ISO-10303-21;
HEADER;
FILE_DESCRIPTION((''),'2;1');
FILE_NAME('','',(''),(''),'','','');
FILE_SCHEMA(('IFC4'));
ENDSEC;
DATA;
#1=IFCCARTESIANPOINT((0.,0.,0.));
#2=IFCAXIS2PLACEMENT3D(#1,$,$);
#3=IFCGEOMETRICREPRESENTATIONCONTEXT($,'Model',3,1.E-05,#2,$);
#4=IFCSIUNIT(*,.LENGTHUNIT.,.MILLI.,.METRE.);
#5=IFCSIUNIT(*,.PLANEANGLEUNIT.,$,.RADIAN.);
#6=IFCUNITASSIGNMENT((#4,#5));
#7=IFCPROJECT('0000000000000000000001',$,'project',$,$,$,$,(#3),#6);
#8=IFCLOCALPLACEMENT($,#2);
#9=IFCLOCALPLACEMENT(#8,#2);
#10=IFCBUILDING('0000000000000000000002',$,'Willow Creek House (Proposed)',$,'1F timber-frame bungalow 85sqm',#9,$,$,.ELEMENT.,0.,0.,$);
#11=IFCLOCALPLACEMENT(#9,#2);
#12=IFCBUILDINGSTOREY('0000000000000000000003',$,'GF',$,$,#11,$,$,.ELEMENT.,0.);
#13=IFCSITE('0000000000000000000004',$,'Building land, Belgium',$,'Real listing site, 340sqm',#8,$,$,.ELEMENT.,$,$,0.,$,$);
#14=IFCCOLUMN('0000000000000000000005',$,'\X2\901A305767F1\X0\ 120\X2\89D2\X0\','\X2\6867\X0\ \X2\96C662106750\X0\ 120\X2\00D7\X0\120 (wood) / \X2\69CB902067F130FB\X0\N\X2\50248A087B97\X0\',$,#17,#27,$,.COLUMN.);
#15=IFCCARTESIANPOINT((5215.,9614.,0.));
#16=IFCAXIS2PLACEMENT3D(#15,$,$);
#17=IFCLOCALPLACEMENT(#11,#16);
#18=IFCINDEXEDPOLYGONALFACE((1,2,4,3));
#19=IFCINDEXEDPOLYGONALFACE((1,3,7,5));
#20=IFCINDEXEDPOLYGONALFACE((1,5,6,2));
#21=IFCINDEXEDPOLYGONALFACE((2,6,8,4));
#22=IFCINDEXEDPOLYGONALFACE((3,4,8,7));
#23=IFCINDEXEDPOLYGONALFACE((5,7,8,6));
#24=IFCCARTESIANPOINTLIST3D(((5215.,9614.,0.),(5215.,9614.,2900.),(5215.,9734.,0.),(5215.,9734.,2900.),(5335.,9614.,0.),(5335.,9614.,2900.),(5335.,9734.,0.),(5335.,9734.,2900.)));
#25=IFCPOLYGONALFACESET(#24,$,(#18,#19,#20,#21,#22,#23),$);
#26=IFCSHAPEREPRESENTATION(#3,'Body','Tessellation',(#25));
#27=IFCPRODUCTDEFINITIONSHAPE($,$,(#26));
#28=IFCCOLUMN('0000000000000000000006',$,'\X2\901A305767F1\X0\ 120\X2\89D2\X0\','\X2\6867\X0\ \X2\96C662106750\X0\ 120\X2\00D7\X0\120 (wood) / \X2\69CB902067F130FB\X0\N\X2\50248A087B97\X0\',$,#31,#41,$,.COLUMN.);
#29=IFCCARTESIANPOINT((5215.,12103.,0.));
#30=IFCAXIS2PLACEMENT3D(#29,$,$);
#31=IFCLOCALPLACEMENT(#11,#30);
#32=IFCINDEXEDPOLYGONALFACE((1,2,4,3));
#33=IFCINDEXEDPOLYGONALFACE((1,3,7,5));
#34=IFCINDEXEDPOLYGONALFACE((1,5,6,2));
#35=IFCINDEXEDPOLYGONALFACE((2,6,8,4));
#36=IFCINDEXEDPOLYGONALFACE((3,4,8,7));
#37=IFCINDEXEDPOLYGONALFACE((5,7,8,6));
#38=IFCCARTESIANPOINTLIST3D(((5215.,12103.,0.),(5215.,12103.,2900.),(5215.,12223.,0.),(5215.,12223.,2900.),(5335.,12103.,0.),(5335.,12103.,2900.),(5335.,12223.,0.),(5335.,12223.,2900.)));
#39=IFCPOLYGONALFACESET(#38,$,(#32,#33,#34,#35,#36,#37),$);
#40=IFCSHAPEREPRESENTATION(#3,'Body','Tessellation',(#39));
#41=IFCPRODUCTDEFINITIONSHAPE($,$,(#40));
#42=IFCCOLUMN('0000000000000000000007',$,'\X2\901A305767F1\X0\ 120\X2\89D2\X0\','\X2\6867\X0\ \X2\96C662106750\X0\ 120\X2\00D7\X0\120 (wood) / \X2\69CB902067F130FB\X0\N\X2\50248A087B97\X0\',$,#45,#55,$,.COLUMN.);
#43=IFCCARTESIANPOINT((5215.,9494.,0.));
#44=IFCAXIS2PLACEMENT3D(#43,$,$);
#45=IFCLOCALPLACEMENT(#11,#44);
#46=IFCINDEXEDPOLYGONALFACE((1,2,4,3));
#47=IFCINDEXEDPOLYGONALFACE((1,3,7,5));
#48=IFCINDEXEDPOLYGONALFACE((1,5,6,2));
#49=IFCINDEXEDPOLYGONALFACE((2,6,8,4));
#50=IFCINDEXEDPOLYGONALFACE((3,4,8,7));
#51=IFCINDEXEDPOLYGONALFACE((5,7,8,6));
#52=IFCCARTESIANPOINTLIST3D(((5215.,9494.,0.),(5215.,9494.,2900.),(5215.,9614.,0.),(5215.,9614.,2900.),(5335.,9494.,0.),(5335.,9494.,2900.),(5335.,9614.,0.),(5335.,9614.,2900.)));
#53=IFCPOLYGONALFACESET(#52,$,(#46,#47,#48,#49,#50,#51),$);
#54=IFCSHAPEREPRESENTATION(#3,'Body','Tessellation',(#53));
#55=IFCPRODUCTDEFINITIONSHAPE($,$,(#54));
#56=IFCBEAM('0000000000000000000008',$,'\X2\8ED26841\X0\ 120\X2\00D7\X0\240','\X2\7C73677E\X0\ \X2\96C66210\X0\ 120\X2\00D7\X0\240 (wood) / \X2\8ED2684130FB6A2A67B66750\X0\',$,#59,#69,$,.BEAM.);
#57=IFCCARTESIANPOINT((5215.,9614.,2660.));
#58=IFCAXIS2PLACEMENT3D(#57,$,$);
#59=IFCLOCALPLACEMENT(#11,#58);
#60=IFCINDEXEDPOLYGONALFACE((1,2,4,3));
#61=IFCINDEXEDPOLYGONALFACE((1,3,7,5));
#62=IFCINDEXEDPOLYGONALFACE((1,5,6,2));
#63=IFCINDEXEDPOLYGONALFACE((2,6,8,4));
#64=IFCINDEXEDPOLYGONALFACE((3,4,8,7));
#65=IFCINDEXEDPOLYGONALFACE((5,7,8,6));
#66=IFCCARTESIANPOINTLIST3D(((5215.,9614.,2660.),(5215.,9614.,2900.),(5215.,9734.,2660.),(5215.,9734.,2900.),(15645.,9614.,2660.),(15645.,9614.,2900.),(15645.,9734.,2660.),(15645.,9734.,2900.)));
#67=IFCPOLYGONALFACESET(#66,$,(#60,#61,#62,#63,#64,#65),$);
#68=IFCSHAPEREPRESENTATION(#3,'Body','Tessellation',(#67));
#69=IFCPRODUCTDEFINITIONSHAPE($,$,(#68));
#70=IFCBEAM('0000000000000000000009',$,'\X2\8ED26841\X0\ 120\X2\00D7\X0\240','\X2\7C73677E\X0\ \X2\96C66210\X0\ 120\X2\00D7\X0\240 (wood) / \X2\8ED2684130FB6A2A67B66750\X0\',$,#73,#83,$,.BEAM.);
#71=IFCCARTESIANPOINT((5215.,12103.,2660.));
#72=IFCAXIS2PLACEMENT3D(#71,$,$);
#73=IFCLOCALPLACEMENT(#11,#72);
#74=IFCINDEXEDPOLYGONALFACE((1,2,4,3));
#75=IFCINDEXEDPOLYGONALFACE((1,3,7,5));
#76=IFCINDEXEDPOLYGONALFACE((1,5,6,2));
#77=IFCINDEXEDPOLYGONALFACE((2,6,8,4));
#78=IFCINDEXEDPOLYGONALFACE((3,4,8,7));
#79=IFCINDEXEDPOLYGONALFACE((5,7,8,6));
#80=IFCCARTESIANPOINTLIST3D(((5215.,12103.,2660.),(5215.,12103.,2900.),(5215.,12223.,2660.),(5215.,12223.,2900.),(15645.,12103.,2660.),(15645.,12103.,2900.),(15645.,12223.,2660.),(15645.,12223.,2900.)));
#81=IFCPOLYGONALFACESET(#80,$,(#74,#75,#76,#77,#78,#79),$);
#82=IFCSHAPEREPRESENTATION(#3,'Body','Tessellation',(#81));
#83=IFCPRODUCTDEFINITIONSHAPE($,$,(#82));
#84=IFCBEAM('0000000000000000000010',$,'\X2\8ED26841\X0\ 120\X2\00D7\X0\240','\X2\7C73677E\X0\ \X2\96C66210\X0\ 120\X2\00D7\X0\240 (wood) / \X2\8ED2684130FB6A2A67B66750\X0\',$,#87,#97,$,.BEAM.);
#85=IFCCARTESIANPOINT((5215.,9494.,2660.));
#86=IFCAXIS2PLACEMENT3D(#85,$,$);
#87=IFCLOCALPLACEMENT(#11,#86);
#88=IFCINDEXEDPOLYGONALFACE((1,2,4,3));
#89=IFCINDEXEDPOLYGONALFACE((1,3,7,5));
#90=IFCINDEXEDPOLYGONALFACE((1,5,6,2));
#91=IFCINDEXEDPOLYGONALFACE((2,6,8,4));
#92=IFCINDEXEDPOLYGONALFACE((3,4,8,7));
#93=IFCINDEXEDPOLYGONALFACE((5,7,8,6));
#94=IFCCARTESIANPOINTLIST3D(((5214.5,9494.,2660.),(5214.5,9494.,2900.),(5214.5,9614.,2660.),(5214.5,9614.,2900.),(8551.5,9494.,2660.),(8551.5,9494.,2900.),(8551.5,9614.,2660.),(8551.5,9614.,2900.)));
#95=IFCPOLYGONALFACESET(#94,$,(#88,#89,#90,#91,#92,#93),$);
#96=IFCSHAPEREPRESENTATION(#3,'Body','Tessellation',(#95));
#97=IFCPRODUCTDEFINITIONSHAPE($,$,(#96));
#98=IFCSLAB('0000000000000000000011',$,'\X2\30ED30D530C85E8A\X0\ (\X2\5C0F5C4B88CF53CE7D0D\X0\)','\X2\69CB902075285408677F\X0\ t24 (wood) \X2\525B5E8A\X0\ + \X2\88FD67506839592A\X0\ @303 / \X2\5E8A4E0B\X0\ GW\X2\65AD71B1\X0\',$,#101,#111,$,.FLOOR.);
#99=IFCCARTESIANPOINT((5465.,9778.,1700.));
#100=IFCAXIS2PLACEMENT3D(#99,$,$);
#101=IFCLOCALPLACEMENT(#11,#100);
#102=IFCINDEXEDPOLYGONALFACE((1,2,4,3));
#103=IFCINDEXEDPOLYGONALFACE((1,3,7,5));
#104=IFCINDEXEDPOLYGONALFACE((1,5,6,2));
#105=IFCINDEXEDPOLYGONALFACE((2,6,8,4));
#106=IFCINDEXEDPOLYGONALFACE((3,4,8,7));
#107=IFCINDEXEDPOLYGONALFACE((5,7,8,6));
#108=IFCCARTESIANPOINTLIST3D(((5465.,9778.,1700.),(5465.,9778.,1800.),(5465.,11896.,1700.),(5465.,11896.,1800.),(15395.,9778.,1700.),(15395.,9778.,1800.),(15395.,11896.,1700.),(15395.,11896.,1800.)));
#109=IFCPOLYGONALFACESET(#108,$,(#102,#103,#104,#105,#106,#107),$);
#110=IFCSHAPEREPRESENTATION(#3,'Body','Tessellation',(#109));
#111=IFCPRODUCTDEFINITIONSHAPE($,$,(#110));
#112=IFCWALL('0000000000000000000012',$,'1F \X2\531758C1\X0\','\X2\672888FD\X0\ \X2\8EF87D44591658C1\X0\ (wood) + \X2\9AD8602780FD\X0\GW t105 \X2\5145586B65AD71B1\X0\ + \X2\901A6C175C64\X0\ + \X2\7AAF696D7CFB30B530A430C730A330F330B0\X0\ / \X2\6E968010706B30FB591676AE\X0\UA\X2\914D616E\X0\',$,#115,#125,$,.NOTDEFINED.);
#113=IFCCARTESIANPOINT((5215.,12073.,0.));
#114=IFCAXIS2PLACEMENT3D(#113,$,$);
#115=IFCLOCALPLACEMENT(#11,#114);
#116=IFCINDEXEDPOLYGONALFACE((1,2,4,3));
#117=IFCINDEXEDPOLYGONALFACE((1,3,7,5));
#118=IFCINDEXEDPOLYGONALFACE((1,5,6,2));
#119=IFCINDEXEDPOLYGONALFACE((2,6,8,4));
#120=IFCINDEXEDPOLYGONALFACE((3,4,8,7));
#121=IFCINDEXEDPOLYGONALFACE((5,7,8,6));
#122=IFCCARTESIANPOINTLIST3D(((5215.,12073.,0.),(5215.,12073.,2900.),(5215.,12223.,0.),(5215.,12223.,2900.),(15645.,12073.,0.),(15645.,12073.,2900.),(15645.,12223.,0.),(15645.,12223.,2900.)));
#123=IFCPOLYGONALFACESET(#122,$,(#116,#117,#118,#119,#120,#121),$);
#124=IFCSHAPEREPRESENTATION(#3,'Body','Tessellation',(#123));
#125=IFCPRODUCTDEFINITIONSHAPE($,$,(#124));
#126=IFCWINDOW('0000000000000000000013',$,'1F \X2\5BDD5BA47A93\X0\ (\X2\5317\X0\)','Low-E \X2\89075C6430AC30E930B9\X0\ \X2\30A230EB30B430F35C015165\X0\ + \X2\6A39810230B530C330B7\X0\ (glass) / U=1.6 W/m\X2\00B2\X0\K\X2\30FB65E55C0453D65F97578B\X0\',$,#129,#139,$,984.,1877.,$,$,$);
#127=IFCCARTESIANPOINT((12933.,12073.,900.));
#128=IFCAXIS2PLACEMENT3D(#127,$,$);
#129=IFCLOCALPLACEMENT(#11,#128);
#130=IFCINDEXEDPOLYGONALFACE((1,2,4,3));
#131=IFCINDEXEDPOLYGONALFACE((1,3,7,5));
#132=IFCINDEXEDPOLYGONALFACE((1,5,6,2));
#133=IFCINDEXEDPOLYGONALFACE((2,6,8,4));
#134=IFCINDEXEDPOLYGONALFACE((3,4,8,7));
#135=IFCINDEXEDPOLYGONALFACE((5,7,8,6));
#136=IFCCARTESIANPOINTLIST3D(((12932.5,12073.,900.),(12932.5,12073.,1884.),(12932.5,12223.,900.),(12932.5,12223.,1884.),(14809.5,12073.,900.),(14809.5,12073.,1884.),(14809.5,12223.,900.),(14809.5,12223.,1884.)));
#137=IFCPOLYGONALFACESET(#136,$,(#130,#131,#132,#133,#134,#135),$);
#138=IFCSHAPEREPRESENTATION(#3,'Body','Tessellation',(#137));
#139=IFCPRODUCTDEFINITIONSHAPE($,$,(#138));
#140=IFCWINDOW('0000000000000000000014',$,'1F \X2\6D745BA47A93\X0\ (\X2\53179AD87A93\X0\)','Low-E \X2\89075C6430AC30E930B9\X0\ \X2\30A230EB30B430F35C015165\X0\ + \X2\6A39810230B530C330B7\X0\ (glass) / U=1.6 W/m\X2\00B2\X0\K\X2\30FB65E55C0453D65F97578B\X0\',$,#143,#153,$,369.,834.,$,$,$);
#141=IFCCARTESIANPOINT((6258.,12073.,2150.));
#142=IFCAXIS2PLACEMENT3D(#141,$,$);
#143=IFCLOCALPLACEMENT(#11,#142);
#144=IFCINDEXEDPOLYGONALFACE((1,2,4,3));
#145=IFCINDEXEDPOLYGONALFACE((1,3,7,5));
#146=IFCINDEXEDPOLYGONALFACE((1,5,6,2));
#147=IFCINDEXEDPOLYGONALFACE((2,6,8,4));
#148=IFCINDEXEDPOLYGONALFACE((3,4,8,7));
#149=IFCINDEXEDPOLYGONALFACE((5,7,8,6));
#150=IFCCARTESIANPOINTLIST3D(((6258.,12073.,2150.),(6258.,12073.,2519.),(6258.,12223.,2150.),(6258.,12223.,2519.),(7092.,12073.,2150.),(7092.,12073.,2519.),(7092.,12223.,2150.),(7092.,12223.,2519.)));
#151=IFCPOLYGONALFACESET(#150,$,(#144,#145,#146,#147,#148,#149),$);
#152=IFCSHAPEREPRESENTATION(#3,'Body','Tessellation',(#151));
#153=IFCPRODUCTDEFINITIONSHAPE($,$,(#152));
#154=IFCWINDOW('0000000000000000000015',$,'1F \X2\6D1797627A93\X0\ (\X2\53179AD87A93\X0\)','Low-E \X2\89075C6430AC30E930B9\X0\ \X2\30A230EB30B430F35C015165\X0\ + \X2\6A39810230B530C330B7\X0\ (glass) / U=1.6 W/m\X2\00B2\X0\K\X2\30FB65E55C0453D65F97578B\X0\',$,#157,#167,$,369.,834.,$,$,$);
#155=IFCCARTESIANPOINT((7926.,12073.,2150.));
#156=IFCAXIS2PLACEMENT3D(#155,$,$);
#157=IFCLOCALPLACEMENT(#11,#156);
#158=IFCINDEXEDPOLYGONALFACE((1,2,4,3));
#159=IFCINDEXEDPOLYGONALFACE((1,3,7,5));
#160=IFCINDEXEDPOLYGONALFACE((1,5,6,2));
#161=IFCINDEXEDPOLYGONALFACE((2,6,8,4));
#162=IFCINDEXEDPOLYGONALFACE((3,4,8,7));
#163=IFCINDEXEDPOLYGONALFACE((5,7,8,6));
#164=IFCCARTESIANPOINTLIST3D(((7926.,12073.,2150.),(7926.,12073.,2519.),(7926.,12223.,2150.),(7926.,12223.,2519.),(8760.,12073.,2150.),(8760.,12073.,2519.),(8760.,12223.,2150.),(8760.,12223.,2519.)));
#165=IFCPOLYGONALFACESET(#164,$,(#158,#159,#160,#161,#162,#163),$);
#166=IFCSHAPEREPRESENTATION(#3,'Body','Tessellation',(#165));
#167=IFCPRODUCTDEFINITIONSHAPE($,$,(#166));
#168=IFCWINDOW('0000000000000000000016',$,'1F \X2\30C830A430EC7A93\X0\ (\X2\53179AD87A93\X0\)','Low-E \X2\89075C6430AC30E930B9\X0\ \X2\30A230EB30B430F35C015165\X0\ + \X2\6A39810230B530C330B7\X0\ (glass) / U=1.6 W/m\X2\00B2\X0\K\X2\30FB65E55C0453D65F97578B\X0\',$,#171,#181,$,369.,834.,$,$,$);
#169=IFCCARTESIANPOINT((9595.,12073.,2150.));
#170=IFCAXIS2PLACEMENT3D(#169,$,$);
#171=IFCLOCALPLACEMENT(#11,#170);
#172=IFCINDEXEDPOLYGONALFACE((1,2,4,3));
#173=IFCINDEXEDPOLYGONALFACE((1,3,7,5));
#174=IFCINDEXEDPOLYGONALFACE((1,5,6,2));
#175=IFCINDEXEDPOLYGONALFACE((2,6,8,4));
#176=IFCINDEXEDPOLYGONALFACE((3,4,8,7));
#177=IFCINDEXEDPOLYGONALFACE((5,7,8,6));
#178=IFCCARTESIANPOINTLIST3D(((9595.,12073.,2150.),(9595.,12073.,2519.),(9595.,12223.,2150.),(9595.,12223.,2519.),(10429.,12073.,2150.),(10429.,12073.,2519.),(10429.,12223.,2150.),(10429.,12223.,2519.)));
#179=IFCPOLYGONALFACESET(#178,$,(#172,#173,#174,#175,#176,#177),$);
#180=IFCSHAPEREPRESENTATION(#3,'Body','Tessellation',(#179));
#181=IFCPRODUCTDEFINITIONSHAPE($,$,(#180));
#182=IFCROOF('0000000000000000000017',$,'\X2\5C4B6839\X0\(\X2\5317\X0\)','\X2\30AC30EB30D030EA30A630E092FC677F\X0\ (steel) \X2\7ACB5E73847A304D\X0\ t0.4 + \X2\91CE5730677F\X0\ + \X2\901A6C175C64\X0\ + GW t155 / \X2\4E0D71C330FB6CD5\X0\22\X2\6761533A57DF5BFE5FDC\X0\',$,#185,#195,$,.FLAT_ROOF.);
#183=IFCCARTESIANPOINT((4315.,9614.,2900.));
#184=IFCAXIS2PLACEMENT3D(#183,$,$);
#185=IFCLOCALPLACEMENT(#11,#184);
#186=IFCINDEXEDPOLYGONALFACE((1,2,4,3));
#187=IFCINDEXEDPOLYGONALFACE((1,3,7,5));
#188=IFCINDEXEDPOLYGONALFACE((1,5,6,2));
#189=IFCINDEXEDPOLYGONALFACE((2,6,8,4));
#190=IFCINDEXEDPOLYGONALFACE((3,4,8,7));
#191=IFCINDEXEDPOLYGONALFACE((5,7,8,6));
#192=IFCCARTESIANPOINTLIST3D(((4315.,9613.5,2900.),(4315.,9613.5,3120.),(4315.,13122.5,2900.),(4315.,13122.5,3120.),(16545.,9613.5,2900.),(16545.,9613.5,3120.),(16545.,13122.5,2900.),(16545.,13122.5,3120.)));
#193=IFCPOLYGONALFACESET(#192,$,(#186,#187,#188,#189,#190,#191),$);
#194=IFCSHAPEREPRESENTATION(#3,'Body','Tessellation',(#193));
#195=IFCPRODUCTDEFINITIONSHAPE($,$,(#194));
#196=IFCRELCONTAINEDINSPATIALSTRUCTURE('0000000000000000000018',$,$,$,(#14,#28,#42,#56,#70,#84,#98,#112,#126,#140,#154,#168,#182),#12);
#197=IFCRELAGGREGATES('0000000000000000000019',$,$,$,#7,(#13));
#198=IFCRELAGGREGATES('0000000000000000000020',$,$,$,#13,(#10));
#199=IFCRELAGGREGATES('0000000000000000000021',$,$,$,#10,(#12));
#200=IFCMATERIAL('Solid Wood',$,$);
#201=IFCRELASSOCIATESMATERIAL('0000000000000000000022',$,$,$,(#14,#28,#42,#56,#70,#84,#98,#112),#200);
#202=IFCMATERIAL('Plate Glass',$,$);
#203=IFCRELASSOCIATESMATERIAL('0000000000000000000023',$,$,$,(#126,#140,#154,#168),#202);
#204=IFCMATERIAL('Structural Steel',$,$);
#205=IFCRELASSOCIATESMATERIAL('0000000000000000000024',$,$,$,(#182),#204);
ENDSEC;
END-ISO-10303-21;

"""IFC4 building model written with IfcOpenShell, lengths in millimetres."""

from ifc_helpers import new_model, si_unit, frame, frame_2d, origin, place, context, project, spatial, rectangle, extrude, material, element, fill, save


model = new_model("IFC4")

# Units and contexts
model_context = context("Model", 3, precision=1e-05, world=origin())
ifc_project = project(units=[si_unit("LENGTHUNIT", "METRE", prefix="MILLI"), si_unit("PLANEANGLEUNIT", "RADIAN")], contexts=[model_context])

# Site, building, storey
site_placement = place(None, origin())
site = spatial("IfcSite", under=ifc_project, at=site_placement, Name="Building land, Belgium", ObjectType="Real listing site, 340sqm", CompositionType="ELEMENT", RefElevation=0.0)
building_placement = place(site_placement, origin())
building = spatial("IfcBuilding", under=site, at=building_placement, Name="Willow Creek House (Proposed)", ObjectType="1F timber-frame bungalow 85sqm", CompositionType="ELEMENT", ElevationOfRefHeight=0.0, ElevationOfTerrain=0.0)
storey_placement = place(building_placement, origin())
storey = spatial("IfcBuildingStorey", under=building, at=storey_placement, Name="GF", CompositionType="ELEMENT", Elevation=0.0)

# Columns
ifc_material_1 = material(Name="Solid Wood")
column_1_placement = place(storey_placement, frame((5215.0, 9614.0, 0.0)))
element("IfcColumn", 1, at=column_1_placement, inside=storey, material=ifc_material_1, Name="通し柱 120角", Description="桧 集成材 120×120 (wood) / 構造柱・N値計算", PredefinedType="COLUMN", context=model_context, shape_type="SweptSolid", body=[
    extrude(rectangle(XDim=120.0, YDim=120.0, at=frame_2d((60.0, 60.0))), frame((5215.0, 9614.0, 0.0)), (0.0, 0.0, 1.0), 2900.0),
])
column_2_placement = place(storey_placement, frame((5215.0, 12103.0, 0.0)))
element("IfcColumn", 2, at=column_2_placement, inside=storey, material=ifc_material_1, Name="通し柱 120角", Description="桧 集成材 120×120 (wood) / 構造柱・N値計算", PredefinedType="COLUMN", context=model_context, shape_type="SweptSolid", body=[
    extrude(rectangle(XDim=120.0, YDim=120.0, at=frame_2d((60.0, 60.0))), frame((5215.0, 12103.0, 0.0)), (0.0, 0.0, 1.0), 2900.0),
])
column_3_placement = place(storey_placement, frame((5215.0, 9494.0, 0.0)))
element("IfcColumn", 3, at=column_3_placement, inside=storey, material=ifc_material_1, Name="通し柱 120角", Description="桧 集成材 120×120 (wood) / 構造柱・N値計算", PredefinedType="COLUMN", context=model_context, shape_type="SweptSolid", body=[
    extrude(rectangle(XDim=120.0, YDim=120.0, at=frame_2d((60.0, 60.0))), frame((5215.0, 9494.0, 0.0)), (0.0, 0.0, 1.0), 2900.0),
])

# Beams
beam_1_placement = place(storey_placement, frame((5215.0, 9614.0, 2660.0)))
element("IfcBeam", 4, at=beam_1_placement, inside=storey, material=ifc_material_1, Name="軒桁 120×240", Description="米松 集成 120×240 (wood) / 軒桁・横架材", PredefinedType="BEAM", context=model_context, shape_type="SweptSolid", body=[
    extrude(rectangle(XDim=10430.0, YDim=120.0, at=frame_2d((5215.0, 60.0))), frame((5215.0, 9614.0, 2660.0)), (0.0, 0.0, 1.0), 240.0),
])
beam_2_placement = place(storey_placement, frame((5215.0, 12103.0, 2660.0)))
element("IfcBeam", 5, at=beam_2_placement, inside=storey, material=ifc_material_1, Name="軒桁 120×240", Description="米松 集成 120×240 (wood) / 軒桁・横架材", PredefinedType="BEAM", context=model_context, shape_type="SweptSolid", body=[
    extrude(rectangle(XDim=10430.0, YDim=120.0, at=frame_2d((5215.0, 60.0))), frame((5215.0, 12103.0, 2660.0)), (0.0, 0.0, 1.0), 240.0),
])
beam_3_placement = place(storey_placement, frame((5215.0, 9494.0, 2660.0)))
element("IfcBeam", 6, at=beam_3_placement, inside=storey, material=ifc_material_1, Name="軒桁 120×240", Description="米松 集成 120×240 (wood) / 軒桁・横架材", PredefinedType="BEAM", context=model_context, shape_type="SweptSolid", body=[
    extrude(rectangle(XDim=3337.0, YDim=120.0, at=frame_2d((1668.0, 60.0))), frame((5215.0, 9494.0, 2660.0)), (0.0, 0.0, 1.0), 240.0),
])

# Slab
slab_1_placement = place(storey_placement, frame((5465.0, 9778.0, 1700.0)))
element("IfcSlab", 7, at=slab_1_placement, inside=storey, material=ifc_material_1, Name="ロフト床 (小屋裏収納)", Description="構造用合板 t24 (wood) 剛床 + 製材根太 @303 / 床下 GW断熱", PredefinedType="FLOOR", context=model_context, shape_type="SweptSolid", body=[
    extrude(rectangle(XDim=9930.0, YDim=2118.0, at=frame_2d((4965.0, 1059.0))), frame((5465.0, 9778.0, 1700.0)), (0.0, 0.0, 1.0), 100.0),
])

# Wall, openings, windows
wall_1_placement = place(storey_placement, frame((5215.0, 12073.0, 0.0)))
wall_1 = element("IfcWall", 8, at=wall_1_placement, inside=storey, material=ifc_material_1, Name="1F 北壁", Description="木製 軸組外壁 (wood) + 高性能GW t105 充填断熱 + 通気層 + 窯業系サイディング / 準耐火・外皮UA配慮", PredefinedType="NOTDEFINED", context=model_context, shape_type="SweptSolid", body=[
    extrude(rectangle(XDim=10430.0, YDim=150.0, at=frame_2d((5215.0, 75.0))), frame((5215.0, 12073.0, 0.0)), (0.0, 0.0, 1.0), 2900.0),
])
opening_1_placement = place(storey_placement, frame((12933.0, 12073.0, 900.0)))
opening_1 = element("IfcOpeningElement", 9, at=opening_1_placement, cuts=wall_1, PredefinedType="NOTDEFINED", context=model_context, shape_type="SweptSolid", body=[
    extrude(rectangle(XDim=1877.0, YDim=150.0, at=frame_2d((938.0, 75.0))), frame((12933.0, 12073.0, 900.0)), (0.0, 0.0, 1.0), 984.0),
])
opening_2_placement = place(storey_placement, frame((6258.0, 12073.0, 2150.0)))
opening_2 = element("IfcOpeningElement", 10, at=opening_2_placement, cuts=wall_1, PredefinedType="NOTDEFINED", context=model_context, shape_type="SweptSolid", body=[
    extrude(rectangle(XDim=834.0, YDim=150.0, at=frame_2d((417.0, 75.0))), frame((6258.0, 12073.0, 2150.0)), (0.0, 0.0, 1.0), 369.0),
])
opening_3_placement = place(storey_placement, frame((7926.0, 12073.0, 2150.0)))
opening_3 = element("IfcOpeningElement", 11, at=opening_3_placement, cuts=wall_1, PredefinedType="NOTDEFINED", context=model_context, shape_type="SweptSolid", body=[
    extrude(rectangle(XDim=834.0, YDim=150.0, at=frame_2d((417.0, 75.0))), frame((7926.0, 12073.0, 2150.0)), (0.0, 0.0, 1.0), 369.0),
])
opening_4_placement = place(storey_placement, frame((9595.0, 12073.0, 2150.0)))
opening_4 = element("IfcOpeningElement", 12, at=opening_4_placement, cuts=wall_1, PredefinedType="NOTDEFINED", context=model_context, shape_type="SweptSolid", body=[
    extrude(rectangle(XDim=834.0, YDim=150.0, at=frame_2d((417.0, 75.0))), frame((9595.0, 12073.0, 2150.0)), (0.0, 0.0, 1.0), 369.0),
])
ifc_material_2 = material(Name="Plate Glass")
window_1_placement = place(storey_placement, frame((12933.0, 12073.0, 900.0)))
window_1 = element("IfcWindow", 13, at=window_1_placement, inside=storey, material=ifc_material_2, Name="1F 寝室窓 (北)", Description="Low-E 複層ガラス アルゴン封入 + 樹脂サッシ (glass) / U=1.6 W/m²K・日射取得型", OverallHeight=984.0, OverallWidth=1877.0, context=model_context, shape_type="SweptSolid", body=[
    extrude(rectangle(XDim=1877.0, YDim=150.0, at=frame_2d((938.0, 75.0))), frame((12933.0, 12073.0, 900.0)), (0.0, 0.0, 1.0), 984.0),
])
fill(opening_1, window_1)
window_2_placement = place(storey_placement, frame((6258.0, 12073.0, 2150.0)))
window_2 = element("IfcWindow", 14, at=window_2_placement, inside=storey, material=ifc_material_2, Name="1F 浴室窓 (北高窓)", Description="Low-E 複層ガラス アルゴン封入 + 樹脂サッシ (glass) / U=1.6 W/m²K・日射取得型", OverallHeight=369.0, OverallWidth=834.0, context=model_context, shape_type="SweptSolid", body=[
    extrude(rectangle(XDim=834.0, YDim=150.0, at=frame_2d((417.0, 75.0))), frame((6258.0, 12073.0, 2150.0)), (0.0, 0.0, 1.0), 369.0),
])
fill(opening_2, window_2)
window_3_placement = place(storey_placement, frame((7926.0, 12073.0, 2150.0)))
window_3 = element("IfcWindow", 15, at=window_3_placement, inside=storey, material=ifc_material_2, Name="1F 洗面窓 (北高窓)", Description="Low-E 複層ガラス アルゴン封入 + 樹脂サッシ (glass) / U=1.6 W/m²K・日射取得型", OverallHeight=369.0, OverallWidth=834.0, context=model_context, shape_type="SweptSolid", body=[
    extrude(rectangle(XDim=834.0, YDim=150.0, at=frame_2d((417.0, 75.0))), frame((7926.0, 12073.0, 2150.0)), (0.0, 0.0, 1.0), 369.0),
])
fill(opening_3, window_3)
window_4_placement = place(storey_placement, frame((9595.0, 12073.0, 2150.0)))
window_4 = element("IfcWindow", 16, at=window_4_placement, inside=storey, material=ifc_material_2, Name="1F トイレ窓 (北高窓)", Description="Low-E 複層ガラス アルゴン封入 + 樹脂サッシ (glass) / U=1.6 W/m²K・日射取得型", OverallHeight=369.0, OverallWidth=834.0, context=model_context, shape_type="SweptSolid", body=[
    extrude(rectangle(XDim=834.0, YDim=150.0, at=frame_2d((417.0, 75.0))), frame((9595.0, 12073.0, 2150.0)), (0.0, 0.0, 1.0), 369.0),
])
fill(opening_4, window_4)

# Roof
ifc_material_3 = material(Name="Structural Steel")
roof_placement = place(storey_placement, frame((4315.0, 9614.0, 2900.0)))
element("IfcRoof", 17, at=roof_placement, inside=storey, material=ifc_material_3, Name="屋根(北)", Description="ガルバリウム鋼板 (steel) 立平葺き t0.4 + 野地板 + 通気層 + GW t155 / 不燃・法22条区域対応", PredefinedType="FLAT_ROOF", context=model_context, shape_type="SweptSolid", body=[
    extrude(rectangle(XDim=12230.0, YDim=3509.0, at=frame_2d((6115.0, 1754.0))), frame((4315.0, 9614.0, 2900.0)), (0.0, 0.0, 1.0), 220.0),
])

save(model, "model.ifc")
